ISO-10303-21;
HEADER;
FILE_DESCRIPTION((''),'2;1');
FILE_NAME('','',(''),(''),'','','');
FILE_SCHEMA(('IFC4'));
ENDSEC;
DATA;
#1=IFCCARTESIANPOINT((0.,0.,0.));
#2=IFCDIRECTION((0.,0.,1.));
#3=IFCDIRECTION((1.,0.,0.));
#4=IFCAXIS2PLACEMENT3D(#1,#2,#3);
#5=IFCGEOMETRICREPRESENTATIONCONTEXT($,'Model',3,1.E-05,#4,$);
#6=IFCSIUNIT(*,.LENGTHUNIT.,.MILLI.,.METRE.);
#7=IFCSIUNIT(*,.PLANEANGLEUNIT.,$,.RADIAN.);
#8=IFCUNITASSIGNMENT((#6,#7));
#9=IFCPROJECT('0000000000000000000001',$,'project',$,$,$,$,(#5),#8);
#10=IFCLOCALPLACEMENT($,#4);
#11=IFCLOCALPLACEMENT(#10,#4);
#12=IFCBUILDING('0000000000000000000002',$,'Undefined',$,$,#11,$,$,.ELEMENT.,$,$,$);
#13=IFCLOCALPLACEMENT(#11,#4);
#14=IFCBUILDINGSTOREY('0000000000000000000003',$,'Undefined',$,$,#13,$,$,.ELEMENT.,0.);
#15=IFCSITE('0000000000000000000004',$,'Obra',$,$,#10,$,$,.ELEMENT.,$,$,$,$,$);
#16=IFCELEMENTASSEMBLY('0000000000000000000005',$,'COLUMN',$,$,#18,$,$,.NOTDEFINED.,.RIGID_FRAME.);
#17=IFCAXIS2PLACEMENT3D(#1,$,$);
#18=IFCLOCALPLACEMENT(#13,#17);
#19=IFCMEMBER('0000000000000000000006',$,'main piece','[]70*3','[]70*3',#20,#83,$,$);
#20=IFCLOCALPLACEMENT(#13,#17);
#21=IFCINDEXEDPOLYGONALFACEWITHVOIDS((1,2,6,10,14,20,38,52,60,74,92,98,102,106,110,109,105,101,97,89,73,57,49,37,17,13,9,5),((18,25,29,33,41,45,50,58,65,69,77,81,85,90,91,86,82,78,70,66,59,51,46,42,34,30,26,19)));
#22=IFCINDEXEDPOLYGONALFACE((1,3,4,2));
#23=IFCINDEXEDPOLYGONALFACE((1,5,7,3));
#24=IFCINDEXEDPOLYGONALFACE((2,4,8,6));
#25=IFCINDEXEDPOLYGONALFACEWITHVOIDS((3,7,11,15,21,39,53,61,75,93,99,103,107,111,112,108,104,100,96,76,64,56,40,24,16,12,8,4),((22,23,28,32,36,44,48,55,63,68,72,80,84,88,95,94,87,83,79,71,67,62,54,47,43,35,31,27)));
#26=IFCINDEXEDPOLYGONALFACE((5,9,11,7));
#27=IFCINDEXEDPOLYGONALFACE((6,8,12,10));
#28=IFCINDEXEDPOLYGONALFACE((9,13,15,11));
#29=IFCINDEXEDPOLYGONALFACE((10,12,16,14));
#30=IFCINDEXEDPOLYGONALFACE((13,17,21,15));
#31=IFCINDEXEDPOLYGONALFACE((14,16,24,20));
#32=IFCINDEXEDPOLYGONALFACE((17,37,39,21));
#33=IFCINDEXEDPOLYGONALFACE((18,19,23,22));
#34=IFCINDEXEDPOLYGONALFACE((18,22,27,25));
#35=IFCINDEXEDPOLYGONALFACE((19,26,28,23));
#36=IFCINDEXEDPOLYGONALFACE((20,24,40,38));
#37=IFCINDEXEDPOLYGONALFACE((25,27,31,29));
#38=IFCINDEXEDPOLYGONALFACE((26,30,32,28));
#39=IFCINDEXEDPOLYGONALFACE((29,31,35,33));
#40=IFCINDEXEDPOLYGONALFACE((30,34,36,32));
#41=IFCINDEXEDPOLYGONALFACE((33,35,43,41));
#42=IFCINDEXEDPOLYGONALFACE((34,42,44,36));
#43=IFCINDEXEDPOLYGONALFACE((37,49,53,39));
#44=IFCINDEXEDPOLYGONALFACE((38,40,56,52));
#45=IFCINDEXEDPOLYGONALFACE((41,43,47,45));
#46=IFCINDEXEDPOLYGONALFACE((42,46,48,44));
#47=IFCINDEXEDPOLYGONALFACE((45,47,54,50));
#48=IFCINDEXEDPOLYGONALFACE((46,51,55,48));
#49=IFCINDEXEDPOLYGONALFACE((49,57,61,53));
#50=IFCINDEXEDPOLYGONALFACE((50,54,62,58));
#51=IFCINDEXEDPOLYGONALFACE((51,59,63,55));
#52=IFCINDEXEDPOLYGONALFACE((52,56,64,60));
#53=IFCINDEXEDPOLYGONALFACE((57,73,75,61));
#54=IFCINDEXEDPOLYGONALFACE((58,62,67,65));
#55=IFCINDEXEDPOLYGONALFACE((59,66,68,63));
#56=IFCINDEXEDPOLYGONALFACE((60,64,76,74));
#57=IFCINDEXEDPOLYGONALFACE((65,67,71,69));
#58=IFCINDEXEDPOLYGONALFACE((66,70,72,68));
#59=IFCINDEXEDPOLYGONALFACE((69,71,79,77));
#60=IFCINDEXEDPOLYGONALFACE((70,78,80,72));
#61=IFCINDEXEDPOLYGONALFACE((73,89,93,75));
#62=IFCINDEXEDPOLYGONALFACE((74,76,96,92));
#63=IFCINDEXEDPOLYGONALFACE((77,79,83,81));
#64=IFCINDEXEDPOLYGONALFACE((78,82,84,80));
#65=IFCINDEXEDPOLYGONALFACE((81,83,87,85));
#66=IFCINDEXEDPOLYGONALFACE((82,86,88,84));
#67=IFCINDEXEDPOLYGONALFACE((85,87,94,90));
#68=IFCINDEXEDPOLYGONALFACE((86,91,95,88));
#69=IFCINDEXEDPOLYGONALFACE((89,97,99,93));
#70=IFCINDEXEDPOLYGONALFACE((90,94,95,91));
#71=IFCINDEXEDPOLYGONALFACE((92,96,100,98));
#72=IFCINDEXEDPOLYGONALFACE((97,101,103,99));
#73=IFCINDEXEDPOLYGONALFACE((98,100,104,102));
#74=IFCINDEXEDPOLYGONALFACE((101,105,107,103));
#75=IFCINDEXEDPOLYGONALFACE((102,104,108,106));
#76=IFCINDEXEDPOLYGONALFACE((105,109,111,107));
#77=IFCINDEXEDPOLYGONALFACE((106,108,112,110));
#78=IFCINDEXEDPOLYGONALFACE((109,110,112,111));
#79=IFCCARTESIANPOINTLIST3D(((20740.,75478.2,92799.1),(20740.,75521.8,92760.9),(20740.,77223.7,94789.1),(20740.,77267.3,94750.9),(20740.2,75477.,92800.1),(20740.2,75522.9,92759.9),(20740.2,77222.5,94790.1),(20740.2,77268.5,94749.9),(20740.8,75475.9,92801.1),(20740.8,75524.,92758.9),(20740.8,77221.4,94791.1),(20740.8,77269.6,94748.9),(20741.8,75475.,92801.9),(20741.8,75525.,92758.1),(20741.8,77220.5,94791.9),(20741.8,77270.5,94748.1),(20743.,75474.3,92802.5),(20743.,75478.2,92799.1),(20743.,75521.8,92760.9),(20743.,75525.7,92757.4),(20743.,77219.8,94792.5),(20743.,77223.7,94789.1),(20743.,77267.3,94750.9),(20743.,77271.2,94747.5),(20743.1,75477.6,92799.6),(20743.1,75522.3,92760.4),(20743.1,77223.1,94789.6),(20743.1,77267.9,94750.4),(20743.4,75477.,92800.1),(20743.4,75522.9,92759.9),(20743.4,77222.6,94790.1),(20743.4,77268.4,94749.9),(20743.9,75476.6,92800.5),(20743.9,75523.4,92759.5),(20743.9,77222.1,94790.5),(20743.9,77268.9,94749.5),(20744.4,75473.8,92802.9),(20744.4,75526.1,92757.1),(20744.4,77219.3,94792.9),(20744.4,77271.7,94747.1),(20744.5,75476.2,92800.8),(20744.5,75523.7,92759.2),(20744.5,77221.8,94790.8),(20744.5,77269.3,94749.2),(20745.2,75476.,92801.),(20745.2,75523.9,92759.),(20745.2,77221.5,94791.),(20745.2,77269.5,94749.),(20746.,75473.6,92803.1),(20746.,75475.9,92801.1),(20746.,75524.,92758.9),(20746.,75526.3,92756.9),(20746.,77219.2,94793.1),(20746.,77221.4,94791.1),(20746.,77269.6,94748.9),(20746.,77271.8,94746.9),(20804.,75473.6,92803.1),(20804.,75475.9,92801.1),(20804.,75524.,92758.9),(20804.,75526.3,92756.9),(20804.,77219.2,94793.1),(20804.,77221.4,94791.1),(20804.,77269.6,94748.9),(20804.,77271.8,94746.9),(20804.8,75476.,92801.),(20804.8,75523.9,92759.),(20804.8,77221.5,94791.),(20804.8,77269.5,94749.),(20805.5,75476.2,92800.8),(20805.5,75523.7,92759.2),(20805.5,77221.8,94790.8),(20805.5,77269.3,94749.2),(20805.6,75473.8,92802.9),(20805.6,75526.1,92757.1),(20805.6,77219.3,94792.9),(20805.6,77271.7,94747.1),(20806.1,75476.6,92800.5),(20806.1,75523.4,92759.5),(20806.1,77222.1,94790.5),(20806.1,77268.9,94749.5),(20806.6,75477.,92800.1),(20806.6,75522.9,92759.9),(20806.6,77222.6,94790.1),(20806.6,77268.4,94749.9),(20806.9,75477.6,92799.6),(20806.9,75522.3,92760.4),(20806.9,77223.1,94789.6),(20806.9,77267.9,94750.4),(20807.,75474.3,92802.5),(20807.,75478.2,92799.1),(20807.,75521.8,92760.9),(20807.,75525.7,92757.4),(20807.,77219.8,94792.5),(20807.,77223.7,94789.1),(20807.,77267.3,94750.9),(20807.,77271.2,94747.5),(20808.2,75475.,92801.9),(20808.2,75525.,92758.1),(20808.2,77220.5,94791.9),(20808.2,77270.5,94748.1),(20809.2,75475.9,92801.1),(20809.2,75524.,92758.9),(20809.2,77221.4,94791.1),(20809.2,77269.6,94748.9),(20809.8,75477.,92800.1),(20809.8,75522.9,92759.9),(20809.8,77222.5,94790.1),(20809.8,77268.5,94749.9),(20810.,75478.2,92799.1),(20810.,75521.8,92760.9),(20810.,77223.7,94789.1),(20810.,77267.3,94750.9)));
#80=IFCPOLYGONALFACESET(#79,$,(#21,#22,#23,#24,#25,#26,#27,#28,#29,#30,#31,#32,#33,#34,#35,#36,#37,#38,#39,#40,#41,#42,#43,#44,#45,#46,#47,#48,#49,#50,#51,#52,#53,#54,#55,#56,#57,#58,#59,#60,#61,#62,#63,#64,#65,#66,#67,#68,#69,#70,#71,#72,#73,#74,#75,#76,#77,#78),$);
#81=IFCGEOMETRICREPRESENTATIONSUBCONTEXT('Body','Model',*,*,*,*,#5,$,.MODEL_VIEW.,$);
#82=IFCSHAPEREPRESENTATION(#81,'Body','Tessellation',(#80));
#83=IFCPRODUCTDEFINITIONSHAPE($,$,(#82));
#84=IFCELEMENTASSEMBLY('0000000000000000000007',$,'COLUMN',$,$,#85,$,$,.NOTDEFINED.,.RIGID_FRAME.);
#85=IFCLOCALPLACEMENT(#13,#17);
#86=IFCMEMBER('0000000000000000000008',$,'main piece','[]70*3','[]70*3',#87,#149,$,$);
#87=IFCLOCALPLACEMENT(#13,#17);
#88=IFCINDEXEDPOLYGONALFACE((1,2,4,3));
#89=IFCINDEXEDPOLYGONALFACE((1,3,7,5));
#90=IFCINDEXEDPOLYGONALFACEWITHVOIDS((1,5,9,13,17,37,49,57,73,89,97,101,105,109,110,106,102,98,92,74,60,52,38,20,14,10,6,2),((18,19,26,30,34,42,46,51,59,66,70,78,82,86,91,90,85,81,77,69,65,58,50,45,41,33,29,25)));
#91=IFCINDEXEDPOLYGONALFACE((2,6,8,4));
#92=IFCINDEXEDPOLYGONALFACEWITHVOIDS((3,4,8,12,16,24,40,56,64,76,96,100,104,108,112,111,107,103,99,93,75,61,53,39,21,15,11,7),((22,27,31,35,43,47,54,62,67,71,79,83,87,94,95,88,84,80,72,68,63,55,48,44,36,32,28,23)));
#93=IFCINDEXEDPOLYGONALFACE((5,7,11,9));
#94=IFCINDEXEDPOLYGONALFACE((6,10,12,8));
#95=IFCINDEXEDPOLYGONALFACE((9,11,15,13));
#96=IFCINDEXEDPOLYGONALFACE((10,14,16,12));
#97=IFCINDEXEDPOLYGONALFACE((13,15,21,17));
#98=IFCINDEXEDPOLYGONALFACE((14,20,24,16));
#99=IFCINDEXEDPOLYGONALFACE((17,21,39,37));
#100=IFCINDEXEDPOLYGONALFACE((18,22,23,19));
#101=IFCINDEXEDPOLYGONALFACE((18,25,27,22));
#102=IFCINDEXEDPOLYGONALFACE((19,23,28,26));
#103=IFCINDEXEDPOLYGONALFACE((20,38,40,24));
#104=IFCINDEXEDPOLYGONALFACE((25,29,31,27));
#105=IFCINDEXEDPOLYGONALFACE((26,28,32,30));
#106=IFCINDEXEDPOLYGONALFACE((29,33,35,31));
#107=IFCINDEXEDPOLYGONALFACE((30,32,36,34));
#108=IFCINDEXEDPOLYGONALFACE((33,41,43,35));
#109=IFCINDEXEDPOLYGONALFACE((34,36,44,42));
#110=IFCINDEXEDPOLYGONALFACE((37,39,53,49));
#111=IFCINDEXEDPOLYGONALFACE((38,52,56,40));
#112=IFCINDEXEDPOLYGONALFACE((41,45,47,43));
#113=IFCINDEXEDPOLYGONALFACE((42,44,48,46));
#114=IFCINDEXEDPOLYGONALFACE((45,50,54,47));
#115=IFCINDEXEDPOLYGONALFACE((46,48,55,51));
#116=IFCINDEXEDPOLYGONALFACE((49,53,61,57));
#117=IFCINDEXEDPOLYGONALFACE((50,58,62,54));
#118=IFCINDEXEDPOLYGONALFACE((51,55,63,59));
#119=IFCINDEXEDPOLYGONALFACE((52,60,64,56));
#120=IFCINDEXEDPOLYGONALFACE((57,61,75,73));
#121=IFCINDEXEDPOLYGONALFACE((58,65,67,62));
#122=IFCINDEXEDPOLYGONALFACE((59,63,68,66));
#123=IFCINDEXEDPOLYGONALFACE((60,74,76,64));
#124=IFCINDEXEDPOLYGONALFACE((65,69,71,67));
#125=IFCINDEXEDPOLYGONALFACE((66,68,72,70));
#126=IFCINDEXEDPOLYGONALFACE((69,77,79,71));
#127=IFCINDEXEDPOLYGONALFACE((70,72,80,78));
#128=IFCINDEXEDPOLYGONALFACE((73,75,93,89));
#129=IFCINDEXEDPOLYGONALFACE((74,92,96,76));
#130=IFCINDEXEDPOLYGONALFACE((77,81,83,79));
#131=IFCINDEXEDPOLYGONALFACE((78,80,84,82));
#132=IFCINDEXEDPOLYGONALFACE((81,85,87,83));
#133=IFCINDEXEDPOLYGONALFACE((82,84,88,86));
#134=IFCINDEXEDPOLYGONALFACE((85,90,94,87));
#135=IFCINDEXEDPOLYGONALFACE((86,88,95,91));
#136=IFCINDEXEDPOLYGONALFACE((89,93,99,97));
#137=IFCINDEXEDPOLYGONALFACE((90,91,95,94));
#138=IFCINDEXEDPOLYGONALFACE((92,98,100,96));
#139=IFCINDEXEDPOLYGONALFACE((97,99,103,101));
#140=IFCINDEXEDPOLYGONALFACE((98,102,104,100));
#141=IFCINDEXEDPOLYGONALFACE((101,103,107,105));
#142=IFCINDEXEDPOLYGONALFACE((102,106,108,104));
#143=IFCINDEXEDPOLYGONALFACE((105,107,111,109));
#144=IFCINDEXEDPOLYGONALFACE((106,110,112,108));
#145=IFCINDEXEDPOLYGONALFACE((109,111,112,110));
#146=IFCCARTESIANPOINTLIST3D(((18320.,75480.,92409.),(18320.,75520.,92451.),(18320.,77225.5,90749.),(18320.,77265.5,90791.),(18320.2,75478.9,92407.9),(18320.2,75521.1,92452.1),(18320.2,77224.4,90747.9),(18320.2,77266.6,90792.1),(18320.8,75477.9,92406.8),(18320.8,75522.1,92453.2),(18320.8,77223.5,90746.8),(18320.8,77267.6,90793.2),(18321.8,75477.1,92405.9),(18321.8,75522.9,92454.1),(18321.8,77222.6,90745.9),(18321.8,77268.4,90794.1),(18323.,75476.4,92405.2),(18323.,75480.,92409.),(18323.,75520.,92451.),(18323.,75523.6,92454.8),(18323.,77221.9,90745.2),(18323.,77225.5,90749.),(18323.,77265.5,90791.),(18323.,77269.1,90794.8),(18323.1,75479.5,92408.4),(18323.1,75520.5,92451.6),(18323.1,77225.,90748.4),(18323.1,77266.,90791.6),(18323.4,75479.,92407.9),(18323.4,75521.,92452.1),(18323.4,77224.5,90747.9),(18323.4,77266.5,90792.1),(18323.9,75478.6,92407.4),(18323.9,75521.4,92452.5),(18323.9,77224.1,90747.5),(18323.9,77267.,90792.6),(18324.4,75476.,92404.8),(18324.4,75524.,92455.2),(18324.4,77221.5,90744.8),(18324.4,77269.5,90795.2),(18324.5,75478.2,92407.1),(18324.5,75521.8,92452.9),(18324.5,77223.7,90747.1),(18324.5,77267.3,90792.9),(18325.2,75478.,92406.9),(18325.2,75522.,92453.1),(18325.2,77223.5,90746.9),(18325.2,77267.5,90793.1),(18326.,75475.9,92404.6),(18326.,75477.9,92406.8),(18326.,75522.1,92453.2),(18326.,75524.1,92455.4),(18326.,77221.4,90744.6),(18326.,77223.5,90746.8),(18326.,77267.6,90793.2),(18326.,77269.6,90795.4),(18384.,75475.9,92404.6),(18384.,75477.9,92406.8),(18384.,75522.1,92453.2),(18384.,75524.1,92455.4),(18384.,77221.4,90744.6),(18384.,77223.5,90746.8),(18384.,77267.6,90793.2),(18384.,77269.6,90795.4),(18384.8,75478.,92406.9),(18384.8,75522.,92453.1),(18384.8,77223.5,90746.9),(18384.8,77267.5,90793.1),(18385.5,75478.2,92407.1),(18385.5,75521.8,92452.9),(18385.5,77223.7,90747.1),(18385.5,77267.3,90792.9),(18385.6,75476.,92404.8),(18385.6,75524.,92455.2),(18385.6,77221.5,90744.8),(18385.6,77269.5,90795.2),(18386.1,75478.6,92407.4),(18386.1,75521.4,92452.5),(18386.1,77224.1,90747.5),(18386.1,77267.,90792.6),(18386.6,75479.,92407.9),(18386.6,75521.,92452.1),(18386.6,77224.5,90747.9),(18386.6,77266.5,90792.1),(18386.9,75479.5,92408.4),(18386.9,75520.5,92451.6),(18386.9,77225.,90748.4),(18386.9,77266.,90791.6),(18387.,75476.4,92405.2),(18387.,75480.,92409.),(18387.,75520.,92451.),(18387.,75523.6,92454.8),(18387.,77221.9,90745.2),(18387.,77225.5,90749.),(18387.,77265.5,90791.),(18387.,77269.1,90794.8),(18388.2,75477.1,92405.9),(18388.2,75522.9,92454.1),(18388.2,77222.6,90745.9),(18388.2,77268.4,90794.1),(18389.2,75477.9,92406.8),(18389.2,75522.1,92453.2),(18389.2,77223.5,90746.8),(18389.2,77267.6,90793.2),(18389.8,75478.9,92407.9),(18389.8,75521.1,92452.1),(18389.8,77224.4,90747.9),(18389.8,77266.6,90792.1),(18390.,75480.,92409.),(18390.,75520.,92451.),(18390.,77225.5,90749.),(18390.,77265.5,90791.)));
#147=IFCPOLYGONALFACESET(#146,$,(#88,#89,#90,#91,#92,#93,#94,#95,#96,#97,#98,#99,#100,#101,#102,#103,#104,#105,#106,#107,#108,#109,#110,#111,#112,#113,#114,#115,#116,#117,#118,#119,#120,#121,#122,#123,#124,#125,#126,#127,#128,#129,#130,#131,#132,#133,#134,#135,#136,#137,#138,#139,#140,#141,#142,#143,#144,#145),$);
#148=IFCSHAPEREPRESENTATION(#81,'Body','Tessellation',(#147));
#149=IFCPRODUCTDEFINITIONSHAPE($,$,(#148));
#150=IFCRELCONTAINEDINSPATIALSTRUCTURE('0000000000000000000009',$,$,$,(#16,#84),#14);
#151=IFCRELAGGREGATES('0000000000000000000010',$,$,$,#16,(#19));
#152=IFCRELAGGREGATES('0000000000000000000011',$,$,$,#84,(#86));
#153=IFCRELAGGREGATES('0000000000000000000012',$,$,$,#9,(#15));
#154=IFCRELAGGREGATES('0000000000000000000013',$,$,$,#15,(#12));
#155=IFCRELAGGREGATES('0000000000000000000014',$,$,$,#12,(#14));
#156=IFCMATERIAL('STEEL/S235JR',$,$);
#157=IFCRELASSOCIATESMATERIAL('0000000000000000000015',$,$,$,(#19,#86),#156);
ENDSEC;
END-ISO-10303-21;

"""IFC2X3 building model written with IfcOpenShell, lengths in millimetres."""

from ifc_helpers import new_model, si_unit, frame, origin_with_axes, origin_2d_with_axis, place, context, subcontext, project, spatial, hollow_rectangle, extrude, material, element, aggregate, save


model = new_model("IFC2X3")

# Units and contexts
model_context = context("Model", 3, precision=1e-05, world=origin_with_axes())
body_context = subcontext(model_context, "Body", "Model", "MODEL_VIEW")
ifc_project = project(units=[si_unit("LENGTHUNIT", "METRE", prefix="MILLI"), si_unit("PLANEANGLEUNIT", "RADIAN")], contexts=[model_context])

# Site, building, storey
site_placement = place(None, origin_with_axes())
site = spatial("IfcSite", under=ifc_project, at=site_placement, Name="Obra", CompositionType="ELEMENT")
building_placement = place(site_placement, origin_with_axes())
building = spatial("IfcBuilding", under=site, at=building_placement, Name="Undefined", CompositionType="ELEMENT")
storey_placement = place(building_placement, origin_with_axes())
storey = spatial("IfcBuildingStorey", under=building, at=storey_placement, Name="Undefined", CompositionType="ELEMENT", Elevation=0.0)

# Shared definitions
ifc_material = material(Name="STEEL/S235JR")

# Element assemblies, members
assembly_1_placement = place(storey_placement, origin_with_axes())
assembly_1 = element("IfcElementAssembly", 1, at=assembly_1_placement, inside=storey, Name="COLUMN", AssemblyPlace="NOTDEFINED", PredefinedType="RIGID_FRAME")
member_1_placement = place(assembly_1_placement, frame((20775.0, 75500.0, 92780.0), z_axis=(-1.0, 0.0, 0.0), x_axis=(0.0, 0.659423, 0.751772)))
member_1 = element("IfcMember", 2, at=member_1_placement, material=ifc_material, Name="main piece", Description="[]70*3", ObjectType="[]70*3", context=body_context, shape_type="SweptSolid", body=[
    extrude(hollow_rectangle(XDim=70.0, YDim=70.0, WallThickness=3.0, InnerFilletRadius=3.0, OuterFilletRadius=6.0, at=origin_2d_with_axis()), frame((2647.1, 0.0, 0.0), z_axis=(-1.0, 0.0, 0.0), x_axis=(0.0, -1.0, 0.0)), (0.0, 0.0, 1.0), 2647.1),
])
aggregate(assembly_1, [member_1])
assembly_2_placement = place(storey_placement, origin_with_axes())
assembly_2 = element("IfcElementAssembly", 3, at=assembly_2_placement, inside=storey, Name="COLUMN", AssemblyPlace="NOTDEFINED", PredefinedType="RIGID_FRAME")
member_2_placement = place(assembly_2_placement, frame((18355.0, 77245.5, 90770.0), z_axis=(1.0, 0.0, 0.0), x_axis=(0.0, -0.724633, 0.689135)))
member_2 = element("IfcMember", 4, at=member_2_placement, material=ifc_material, Name="main piece", Description="[]70*3", ObjectType="[]70*3", context=body_context, shape_type="SweptSolid", body=[
    extrude(hollow_rectangle(XDim=70.0, YDim=70.0, WallThickness=3.0, InnerFilletRadius=3.0, OuterFilletRadius=6.0, at=origin_2d_with_axis()), frame((2408.8, 0.0, 0.0), z_axis=(-1.0, 0.0, 0.0), x_axis=(0.0, -1.0, 0.0)), (0.0, 0.0, 1.0), 2408.8),
])
aggregate(assembly_2, [member_2])

save(model, "model.ifc")
